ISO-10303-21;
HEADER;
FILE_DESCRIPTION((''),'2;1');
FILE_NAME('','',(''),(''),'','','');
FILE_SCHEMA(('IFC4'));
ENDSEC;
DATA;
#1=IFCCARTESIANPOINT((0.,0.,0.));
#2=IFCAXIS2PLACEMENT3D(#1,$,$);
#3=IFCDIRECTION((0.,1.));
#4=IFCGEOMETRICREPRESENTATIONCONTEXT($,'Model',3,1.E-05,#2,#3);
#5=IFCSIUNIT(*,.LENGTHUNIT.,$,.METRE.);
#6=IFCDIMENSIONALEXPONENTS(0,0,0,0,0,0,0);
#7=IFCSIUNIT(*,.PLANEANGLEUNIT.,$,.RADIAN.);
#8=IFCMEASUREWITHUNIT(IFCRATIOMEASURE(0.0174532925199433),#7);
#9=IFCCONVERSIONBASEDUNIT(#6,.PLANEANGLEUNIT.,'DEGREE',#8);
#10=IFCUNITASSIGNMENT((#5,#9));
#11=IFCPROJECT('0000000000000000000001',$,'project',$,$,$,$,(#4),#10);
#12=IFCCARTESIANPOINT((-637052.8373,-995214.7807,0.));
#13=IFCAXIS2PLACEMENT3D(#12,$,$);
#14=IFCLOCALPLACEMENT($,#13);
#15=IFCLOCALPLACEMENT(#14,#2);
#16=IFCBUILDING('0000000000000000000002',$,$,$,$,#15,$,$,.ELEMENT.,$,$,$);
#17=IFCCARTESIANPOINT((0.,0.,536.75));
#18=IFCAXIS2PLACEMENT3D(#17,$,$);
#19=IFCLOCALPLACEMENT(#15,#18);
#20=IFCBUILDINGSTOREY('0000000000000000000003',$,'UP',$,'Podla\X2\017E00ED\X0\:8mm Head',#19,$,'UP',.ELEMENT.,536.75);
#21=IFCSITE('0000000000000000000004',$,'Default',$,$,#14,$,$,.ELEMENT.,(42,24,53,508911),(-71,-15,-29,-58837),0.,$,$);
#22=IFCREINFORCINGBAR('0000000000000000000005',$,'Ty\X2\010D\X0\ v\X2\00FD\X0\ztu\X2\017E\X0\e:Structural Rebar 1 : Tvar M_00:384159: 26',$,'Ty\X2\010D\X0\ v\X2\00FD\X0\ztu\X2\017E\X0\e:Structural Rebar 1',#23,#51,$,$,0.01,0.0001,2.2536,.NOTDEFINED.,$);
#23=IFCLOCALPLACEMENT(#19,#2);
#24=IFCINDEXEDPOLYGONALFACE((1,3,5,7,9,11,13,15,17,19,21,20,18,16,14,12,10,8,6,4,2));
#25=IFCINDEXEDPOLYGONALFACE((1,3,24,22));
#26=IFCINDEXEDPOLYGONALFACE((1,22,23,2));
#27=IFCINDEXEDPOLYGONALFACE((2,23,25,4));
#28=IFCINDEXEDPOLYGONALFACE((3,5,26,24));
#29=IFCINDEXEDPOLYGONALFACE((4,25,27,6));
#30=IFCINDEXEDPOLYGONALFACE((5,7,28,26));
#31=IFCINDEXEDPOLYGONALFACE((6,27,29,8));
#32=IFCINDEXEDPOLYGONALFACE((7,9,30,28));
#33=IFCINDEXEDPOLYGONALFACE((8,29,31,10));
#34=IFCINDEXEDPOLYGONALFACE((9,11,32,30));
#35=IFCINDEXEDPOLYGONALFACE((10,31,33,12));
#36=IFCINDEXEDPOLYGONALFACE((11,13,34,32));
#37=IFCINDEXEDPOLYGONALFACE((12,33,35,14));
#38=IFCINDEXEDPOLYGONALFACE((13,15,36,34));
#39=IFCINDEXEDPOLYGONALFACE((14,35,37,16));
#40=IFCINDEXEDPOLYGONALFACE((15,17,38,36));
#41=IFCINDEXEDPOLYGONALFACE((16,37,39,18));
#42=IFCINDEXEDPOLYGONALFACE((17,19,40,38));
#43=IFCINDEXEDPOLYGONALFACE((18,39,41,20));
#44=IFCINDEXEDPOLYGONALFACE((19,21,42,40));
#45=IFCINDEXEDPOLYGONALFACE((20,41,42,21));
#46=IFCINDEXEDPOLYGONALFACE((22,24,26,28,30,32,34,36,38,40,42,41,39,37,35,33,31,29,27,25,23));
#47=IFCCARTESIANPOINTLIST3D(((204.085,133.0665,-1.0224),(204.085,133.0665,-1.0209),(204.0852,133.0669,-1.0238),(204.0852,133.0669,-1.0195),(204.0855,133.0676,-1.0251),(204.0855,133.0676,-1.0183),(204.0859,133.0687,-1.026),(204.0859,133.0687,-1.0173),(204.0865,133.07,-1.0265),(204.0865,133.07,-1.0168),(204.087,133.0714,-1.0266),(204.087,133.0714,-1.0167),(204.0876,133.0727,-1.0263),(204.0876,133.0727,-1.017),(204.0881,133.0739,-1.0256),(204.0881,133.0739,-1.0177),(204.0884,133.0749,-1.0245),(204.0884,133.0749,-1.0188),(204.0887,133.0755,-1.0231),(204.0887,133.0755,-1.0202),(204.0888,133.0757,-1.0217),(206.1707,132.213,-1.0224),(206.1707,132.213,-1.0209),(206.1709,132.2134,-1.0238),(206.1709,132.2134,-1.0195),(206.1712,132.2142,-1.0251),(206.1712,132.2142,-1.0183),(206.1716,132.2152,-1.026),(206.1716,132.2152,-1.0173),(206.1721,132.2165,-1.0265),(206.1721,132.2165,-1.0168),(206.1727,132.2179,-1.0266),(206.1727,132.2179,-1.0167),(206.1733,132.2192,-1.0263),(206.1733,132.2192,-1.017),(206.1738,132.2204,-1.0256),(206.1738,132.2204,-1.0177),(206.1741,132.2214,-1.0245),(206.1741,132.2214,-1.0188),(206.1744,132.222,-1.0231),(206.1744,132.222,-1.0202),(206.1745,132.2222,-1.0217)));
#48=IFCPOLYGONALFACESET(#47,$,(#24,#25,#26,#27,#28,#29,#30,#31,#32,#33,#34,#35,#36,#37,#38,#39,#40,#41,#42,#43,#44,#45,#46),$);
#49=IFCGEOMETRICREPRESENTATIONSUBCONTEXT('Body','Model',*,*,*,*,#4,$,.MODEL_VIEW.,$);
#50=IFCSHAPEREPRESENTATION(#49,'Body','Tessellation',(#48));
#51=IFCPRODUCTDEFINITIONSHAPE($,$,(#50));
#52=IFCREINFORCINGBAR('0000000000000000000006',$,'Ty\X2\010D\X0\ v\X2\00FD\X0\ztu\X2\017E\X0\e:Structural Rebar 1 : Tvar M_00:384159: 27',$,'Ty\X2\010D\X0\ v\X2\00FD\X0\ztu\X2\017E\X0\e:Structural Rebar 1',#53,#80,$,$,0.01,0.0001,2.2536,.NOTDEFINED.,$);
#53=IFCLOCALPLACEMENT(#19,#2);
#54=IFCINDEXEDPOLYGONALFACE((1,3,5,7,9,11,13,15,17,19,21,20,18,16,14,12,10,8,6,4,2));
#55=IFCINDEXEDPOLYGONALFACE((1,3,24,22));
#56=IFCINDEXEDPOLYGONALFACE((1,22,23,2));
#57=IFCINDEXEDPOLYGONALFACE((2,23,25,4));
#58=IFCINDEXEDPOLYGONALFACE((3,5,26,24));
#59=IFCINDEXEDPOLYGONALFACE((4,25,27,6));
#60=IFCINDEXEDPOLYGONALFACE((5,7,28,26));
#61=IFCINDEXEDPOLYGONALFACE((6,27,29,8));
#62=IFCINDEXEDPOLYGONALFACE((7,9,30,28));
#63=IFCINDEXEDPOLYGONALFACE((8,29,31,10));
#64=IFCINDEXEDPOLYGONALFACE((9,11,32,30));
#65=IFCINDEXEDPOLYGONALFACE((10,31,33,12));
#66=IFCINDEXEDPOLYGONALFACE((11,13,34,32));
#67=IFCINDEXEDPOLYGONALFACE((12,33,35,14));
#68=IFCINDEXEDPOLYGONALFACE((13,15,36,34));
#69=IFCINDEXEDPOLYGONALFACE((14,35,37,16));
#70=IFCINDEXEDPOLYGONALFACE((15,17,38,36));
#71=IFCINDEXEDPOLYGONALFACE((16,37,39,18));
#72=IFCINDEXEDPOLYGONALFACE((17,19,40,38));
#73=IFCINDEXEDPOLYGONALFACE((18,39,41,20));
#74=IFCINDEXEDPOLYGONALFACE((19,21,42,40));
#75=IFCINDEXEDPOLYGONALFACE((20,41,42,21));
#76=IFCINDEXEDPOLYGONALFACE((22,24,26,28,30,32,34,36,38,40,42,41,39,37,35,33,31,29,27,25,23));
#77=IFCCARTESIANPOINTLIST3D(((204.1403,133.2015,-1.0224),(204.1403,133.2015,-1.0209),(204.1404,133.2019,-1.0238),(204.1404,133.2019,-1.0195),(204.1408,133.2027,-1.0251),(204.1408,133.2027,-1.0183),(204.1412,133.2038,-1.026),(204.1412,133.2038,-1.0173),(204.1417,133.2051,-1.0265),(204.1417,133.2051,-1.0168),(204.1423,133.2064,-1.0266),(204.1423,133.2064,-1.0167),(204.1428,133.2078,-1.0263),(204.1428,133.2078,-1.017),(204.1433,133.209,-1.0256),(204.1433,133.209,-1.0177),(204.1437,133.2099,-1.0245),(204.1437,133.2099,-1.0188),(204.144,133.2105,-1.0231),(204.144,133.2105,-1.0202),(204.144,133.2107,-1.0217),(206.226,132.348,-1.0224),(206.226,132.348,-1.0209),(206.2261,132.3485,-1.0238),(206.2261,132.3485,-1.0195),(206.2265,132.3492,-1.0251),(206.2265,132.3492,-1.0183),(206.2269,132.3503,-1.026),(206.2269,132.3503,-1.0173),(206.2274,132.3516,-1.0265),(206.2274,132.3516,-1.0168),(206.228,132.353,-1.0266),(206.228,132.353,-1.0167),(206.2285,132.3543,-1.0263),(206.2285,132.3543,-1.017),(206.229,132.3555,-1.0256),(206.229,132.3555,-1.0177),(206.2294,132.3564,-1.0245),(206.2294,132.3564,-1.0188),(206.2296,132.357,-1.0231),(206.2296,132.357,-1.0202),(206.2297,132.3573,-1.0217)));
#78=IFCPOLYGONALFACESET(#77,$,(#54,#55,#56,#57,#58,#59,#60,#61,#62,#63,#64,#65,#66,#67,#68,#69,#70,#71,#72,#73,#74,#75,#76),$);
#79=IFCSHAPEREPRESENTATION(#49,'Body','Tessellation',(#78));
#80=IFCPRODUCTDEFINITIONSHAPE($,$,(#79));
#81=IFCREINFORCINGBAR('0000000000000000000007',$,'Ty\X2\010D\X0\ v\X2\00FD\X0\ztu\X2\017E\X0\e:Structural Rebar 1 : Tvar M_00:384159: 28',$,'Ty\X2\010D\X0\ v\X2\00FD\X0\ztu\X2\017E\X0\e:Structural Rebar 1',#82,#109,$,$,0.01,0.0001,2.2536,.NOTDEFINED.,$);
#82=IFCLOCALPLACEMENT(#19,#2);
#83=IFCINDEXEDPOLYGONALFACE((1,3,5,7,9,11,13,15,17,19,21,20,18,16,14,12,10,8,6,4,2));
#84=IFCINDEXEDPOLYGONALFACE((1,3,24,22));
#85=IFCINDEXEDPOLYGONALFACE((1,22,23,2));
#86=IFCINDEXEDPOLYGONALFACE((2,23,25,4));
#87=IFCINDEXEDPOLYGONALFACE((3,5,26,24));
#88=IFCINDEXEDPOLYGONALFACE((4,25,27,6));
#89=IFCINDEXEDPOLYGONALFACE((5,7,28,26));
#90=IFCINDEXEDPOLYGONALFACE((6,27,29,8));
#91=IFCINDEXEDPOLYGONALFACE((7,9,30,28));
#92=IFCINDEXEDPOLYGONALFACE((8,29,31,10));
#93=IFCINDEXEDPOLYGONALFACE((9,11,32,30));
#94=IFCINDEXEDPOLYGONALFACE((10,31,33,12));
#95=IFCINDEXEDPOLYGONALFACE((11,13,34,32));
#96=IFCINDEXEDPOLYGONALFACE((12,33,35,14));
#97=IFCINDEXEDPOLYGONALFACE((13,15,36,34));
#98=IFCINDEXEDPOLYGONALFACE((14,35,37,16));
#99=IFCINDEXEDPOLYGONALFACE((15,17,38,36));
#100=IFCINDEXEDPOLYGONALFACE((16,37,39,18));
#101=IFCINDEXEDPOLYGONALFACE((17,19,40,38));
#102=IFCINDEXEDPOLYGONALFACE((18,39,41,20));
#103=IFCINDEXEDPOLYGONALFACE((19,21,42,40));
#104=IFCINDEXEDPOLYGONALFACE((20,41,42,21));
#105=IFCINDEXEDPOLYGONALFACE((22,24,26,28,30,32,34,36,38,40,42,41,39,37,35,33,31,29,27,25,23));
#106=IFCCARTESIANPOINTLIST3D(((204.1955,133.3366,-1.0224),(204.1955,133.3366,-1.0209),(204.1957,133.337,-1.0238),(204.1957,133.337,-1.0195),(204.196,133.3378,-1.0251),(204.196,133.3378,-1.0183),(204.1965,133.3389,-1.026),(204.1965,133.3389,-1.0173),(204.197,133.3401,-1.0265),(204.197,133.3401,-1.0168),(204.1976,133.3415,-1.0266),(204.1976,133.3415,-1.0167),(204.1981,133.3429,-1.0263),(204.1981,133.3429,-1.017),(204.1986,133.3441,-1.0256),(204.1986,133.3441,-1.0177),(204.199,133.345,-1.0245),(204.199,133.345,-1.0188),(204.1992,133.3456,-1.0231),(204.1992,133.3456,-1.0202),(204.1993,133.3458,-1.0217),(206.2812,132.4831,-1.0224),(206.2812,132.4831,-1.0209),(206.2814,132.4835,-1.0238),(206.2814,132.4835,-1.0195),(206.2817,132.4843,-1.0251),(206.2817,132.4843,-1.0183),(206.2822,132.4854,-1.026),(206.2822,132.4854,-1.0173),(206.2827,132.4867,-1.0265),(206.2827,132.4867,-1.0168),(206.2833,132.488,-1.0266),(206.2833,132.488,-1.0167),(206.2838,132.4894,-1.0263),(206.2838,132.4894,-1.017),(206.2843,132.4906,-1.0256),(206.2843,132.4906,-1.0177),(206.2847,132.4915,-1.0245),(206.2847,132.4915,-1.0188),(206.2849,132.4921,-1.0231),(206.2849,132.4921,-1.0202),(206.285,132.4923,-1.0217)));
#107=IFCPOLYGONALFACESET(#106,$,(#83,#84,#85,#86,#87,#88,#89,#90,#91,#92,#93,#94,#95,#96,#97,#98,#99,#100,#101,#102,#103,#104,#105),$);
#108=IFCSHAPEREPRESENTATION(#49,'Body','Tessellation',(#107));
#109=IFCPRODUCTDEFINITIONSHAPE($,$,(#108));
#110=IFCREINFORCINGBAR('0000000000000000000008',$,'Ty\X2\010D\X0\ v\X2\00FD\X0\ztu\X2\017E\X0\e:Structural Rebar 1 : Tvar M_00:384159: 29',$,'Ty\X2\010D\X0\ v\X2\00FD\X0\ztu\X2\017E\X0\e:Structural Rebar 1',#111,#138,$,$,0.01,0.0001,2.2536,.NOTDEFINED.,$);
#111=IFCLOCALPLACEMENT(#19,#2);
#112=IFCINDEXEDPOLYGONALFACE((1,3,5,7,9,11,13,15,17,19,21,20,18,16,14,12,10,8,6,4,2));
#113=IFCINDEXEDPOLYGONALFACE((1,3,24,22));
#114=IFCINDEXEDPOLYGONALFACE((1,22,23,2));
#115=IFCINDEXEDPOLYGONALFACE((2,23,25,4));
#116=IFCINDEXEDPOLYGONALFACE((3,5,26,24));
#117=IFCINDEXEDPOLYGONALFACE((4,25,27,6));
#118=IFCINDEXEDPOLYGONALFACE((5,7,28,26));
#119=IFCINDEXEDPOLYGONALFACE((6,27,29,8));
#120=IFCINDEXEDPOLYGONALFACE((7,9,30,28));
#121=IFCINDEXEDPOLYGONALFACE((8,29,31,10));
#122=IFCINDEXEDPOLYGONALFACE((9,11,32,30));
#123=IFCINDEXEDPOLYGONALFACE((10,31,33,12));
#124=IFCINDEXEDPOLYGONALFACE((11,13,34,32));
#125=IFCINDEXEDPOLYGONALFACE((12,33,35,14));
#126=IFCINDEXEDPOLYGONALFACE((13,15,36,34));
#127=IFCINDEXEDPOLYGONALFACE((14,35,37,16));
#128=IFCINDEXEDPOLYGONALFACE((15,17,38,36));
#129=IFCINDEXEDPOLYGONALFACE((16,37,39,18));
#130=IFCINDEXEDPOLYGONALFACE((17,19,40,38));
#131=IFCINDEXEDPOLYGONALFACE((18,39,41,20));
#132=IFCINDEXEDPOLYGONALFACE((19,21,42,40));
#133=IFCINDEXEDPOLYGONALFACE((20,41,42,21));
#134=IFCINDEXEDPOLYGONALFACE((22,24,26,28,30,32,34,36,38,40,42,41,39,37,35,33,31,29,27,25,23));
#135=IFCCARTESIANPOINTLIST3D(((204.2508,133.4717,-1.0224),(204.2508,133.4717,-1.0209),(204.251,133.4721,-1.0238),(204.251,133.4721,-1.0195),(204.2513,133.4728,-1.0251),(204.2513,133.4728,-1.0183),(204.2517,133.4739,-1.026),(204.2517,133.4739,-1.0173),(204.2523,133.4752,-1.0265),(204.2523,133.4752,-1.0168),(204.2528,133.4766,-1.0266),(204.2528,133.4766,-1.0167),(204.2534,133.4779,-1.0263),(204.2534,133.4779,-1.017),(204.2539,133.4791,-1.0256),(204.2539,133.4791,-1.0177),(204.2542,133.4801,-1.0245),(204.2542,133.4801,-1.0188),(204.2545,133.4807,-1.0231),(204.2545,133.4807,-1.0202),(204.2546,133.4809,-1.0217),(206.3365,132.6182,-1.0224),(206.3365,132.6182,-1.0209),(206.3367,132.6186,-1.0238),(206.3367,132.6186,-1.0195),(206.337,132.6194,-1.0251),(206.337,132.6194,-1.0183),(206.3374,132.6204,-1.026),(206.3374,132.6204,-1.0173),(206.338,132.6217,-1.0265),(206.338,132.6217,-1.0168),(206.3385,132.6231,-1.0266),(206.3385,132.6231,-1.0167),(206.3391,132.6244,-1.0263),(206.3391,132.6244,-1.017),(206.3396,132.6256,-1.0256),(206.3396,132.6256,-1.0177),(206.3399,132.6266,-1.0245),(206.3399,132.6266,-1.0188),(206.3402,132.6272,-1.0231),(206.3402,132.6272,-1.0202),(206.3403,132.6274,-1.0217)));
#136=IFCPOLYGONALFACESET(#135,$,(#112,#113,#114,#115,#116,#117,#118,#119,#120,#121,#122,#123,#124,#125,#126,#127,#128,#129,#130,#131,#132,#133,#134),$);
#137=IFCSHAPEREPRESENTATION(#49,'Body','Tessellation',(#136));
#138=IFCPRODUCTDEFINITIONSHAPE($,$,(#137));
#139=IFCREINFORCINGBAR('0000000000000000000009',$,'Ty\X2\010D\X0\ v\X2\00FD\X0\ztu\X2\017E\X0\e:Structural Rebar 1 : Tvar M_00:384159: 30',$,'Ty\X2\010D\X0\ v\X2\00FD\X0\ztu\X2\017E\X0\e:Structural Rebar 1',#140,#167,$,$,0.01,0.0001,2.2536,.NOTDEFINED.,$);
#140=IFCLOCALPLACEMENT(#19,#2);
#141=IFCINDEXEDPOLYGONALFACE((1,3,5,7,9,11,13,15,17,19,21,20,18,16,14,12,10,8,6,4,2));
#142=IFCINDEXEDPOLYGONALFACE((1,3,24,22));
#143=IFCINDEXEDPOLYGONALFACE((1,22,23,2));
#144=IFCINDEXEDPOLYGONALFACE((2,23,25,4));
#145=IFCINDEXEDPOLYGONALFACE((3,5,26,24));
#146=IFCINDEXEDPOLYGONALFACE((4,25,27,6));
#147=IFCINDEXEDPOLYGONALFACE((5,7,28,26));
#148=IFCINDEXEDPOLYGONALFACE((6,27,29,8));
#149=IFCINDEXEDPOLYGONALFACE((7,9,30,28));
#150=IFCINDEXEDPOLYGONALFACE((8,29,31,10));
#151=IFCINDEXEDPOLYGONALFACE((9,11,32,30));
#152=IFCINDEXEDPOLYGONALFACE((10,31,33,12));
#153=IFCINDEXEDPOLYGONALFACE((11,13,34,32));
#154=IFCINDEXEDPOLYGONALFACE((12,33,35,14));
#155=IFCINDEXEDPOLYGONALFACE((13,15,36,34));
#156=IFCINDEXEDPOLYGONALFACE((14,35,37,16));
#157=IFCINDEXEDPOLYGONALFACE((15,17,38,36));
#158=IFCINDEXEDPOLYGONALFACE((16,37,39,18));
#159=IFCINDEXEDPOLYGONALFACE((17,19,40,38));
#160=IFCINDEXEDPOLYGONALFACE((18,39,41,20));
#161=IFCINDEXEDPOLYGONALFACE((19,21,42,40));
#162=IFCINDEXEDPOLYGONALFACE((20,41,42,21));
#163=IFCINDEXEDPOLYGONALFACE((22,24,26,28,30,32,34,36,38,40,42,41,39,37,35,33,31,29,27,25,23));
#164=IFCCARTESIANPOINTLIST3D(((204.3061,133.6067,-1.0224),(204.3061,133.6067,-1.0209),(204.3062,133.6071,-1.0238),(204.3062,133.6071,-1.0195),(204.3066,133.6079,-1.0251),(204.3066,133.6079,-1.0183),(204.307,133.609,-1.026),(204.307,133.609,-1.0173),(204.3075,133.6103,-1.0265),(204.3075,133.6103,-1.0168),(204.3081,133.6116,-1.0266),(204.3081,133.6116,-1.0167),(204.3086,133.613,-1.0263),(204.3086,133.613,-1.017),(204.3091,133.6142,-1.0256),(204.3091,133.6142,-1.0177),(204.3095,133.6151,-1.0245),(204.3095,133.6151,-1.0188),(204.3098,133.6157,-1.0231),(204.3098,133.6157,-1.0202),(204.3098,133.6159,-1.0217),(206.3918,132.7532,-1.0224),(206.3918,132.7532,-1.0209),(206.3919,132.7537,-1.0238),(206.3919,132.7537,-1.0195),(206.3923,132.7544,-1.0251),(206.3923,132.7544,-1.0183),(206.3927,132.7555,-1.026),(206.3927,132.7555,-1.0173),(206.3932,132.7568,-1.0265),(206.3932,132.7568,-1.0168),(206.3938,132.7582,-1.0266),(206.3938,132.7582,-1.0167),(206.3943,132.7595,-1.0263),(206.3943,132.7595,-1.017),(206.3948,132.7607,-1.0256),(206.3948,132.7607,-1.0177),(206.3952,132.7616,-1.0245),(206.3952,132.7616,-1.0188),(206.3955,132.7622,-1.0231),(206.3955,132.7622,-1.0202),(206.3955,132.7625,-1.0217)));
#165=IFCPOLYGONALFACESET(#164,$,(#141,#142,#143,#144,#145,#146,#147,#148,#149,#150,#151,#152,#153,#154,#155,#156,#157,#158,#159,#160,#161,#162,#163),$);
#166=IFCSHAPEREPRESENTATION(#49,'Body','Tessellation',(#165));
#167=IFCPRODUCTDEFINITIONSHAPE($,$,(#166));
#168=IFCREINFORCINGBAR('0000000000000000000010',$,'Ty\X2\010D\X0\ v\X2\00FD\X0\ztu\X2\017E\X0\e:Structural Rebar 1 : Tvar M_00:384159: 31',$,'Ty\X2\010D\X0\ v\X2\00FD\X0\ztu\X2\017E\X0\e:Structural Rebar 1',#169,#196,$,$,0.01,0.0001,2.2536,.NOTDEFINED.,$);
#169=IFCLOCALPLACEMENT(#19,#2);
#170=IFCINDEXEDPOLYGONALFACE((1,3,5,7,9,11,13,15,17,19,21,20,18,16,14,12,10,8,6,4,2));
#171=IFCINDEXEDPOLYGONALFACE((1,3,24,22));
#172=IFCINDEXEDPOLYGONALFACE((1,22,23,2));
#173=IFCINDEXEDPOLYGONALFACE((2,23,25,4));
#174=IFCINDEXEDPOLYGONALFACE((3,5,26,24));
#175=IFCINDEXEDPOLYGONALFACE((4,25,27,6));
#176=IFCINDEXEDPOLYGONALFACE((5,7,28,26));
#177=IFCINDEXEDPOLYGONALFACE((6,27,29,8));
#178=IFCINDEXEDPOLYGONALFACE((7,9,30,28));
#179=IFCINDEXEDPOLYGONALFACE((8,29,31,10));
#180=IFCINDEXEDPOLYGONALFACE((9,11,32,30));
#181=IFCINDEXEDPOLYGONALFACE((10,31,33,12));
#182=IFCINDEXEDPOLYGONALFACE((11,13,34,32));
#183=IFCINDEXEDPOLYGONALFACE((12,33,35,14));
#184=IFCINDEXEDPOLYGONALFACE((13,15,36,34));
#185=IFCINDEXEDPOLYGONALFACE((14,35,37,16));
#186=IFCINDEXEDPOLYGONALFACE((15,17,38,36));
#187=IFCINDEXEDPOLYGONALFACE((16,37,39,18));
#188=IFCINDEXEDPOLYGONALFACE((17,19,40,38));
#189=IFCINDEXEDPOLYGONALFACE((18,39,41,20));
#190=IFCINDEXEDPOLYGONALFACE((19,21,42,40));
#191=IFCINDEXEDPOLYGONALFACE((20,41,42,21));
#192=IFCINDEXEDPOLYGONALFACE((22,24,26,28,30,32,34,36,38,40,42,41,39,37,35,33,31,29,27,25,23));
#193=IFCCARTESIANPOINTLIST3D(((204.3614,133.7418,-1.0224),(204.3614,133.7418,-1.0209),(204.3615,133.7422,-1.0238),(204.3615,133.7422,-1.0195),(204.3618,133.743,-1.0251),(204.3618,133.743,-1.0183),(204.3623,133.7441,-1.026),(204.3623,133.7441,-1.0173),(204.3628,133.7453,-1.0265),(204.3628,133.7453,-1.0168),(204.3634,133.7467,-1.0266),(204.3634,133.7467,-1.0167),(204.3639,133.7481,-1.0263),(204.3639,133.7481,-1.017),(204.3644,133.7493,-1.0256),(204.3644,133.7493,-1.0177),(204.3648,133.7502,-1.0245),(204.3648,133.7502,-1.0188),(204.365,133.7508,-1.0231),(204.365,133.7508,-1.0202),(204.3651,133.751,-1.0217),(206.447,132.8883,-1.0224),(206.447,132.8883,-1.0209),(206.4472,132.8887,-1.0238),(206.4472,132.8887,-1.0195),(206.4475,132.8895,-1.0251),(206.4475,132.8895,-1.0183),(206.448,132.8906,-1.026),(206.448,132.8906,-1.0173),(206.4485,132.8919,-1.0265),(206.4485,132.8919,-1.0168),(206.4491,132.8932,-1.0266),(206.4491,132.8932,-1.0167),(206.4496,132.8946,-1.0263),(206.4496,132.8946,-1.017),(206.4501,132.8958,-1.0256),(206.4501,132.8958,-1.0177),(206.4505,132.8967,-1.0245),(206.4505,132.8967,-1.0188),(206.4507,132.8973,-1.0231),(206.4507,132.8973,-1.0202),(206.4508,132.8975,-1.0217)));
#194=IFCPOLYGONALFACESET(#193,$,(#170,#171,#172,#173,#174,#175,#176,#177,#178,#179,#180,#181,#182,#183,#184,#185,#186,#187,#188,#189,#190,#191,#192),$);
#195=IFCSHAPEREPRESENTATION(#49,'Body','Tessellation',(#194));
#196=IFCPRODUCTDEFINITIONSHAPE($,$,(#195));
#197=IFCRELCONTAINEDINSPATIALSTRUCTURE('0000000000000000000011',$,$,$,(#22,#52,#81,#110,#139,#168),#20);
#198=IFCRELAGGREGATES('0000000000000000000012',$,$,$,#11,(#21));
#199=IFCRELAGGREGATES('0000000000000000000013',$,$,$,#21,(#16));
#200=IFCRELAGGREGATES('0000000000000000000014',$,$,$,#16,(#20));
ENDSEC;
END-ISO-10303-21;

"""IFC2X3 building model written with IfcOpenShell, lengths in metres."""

from ifc_helpers import new_model, entity, si_unit, converted_unit, direction, frame, origin, place, context, subcontext, project, spatial, element, save


model = new_model("IFC2X3")

# Units and contexts
model_context = context("Model", 3, precision=1e-05, world=origin(), true_north=direction((0.0, 1.0)))
body_context = subcontext(model_context, "Body", "Model", "MODEL_VIEW")
ifc_project = project(units=[si_unit("LENGTHUNIT", "METRE"), converted_unit("PLANEANGLEUNIT", "DEGREE", entity("IfcRatioMeasure", 0.0174532925199433), si_unit("PLANEANGLEUNIT", "RADIAN"), dimensions=[0, 0, 0, 0, 0, 0, 0])], contexts=[model_context])

# Site, building, storey
site_placement = place(None, frame((-637052.8373, -995214.7807, 0.0)))
site = spatial("IfcSite", under=ifc_project, at=site_placement, Name="Default", CompositionType="ELEMENT", RefLatitude=(42, 24, 53, 508911), RefLongitude=(-71, -15, -29, -58837), RefElevation=0.0)
building_placement = place(site_placement, origin())
building = spatial("IfcBuilding", under=site, at=building_placement, CompositionType="ELEMENT")
storey_placement = place(building_placement, frame((0.0, 0.0, 536.75)))
storey = spatial("IfcBuildingStorey", under=building, at=storey_placement, Name="UP", ObjectType="Podlaží:8mm Head", LongName="UP", CompositionType="ELEMENT", Elevation=536.75)

# Reinforcing bars
reinforcing_bar_1_placement = place(storey_placement, origin())
element("IfcReinforcingBar", 1, at=reinforcing_bar_1_placement, inside=storey, Name="Tyč výztuže:Structural Rebar 1 : Tvar M_00:384159: 26", ObjectType="Tyč výztuže:Structural Rebar 1", BarLength=2.2536, BarRole="NOTDEFINED", CrossSectionArea=0.0001, NominalDiameter=0.01, context=body_context, shape_type="AdvancedSweptSolid", body=[
    entity("IfcSweptDiskSolid", entity("IfcCompositeCurve", [entity("IfcCompositeCurveSegment", "CONTINUOUS", True, entity("IfcPolyline", [entity("IfcCartesianPoint", [-206.1726, -132.2176, 1.0217]), entity("IfcCartesianPoint", [-204.0869, -133.071, 1.0217])]))], False), 0.005, None, 0.0, 1.0),
])
reinforcing_bar_2_placement = place(storey_placement, origin())
element("IfcReinforcingBar", 2, at=reinforcing_bar_2_placement, inside=storey, Name="Tyč výztuže:Structural Rebar 1 : Tvar M_00:384159: 27", ObjectType="Tyč výztuže:Structural Rebar 1", BarLength=2.2536, BarRole="NOTDEFINED", CrossSectionArea=0.0001, NominalDiameter=0.01, context=body_context, shape_type="AdvancedSweptSolid", body=[
    entity("IfcSweptDiskSolid", entity("IfcCompositeCurve", [entity("IfcCompositeCurveSegment", "CONTINUOUS", True, entity("IfcPolyline", [entity("IfcCartesianPoint", [-206.2278, -132.3526, 1.0217]), entity("IfcCartesianPoint", [-204.1421, -133.2061, 1.0217])]))], False), 0.005, None, 0.0, 1.0),
])
reinforcing_bar_3_placement = place(storey_placement, origin())
element("IfcReinforcingBar", 3, at=reinforcing_bar_3_placement, inside=storey, Name="Tyč výztuže:Structural Rebar 1 : Tvar M_00:384159: 28", ObjectType="Tyč výztuže:Structural Rebar 1", BarLength=2.2536, BarRole="NOTDEFINED", CrossSectionArea=0.0001, NominalDiameter=0.01, context=body_context, shape_type="AdvancedSweptSolid", body=[
    entity("IfcSweptDiskSolid", entity("IfcCompositeCurve", [entity("IfcCompositeCurveSegment", "CONTINUOUS", True, entity("IfcPolyline", [entity("IfcCartesianPoint", [-206.2831, -132.4877, 1.0217]), entity("IfcCartesianPoint", [-204.1974, -133.3412, 1.0217])]))], False), 0.005, None, 0.0, 1.0),
])
reinforcing_bar_4_placement = place(storey_placement, origin())
element("IfcReinforcingBar", 4, at=reinforcing_bar_4_placement, inside=storey, Name="Tyč výztuže:Structural Rebar 1 : Tvar M_00:384159: 29", ObjectType="Tyč výztuže:Structural Rebar 1", BarLength=2.2536, BarRole="NOTDEFINED", CrossSectionArea=0.0001, NominalDiameter=0.01, context=body_context, shape_type="AdvancedSweptSolid", body=[
    entity("IfcSweptDiskSolid", entity("IfcCompositeCurve", [entity("IfcCompositeCurveSegment", "CONTINUOUS", True, entity("IfcPolyline", [entity("IfcCartesianPoint", [-206.3384, -132.6228, 1.0217]), entity("IfcCartesianPoint", [-204.2527, -133.4762, 1.0217])]))], False), 0.005, None, 0.0, 1.0),
])
reinforcing_bar_5_placement = place(storey_placement, origin())
element("IfcReinforcingBar", 5, at=reinforcing_bar_5_placement, inside=storey, Name="Tyč výztuže:Structural Rebar 1 : Tvar M_00:384159: 30", ObjectType="Tyč výztuže:Structural Rebar 1", BarLength=2.2536, BarRole="NOTDEFINED", CrossSectionArea=0.0001, NominalDiameter=0.01, context=body_context, shape_type="AdvancedSweptSolid", body=[
    entity("IfcSweptDiskSolid", entity("IfcCompositeCurve", [entity("IfcCompositeCurveSegment", "CONTINUOUS", True, entity("IfcPolyline", [entity("IfcCartesianPoint", [-206.3936, -132.7578, 1.0217]), entity("IfcCartesianPoint", [-204.308, -133.6113, 1.0217])]))], False), 0.005, None, 0.0, 1.0),
])
reinforcing_bar_6_placement = place(storey_placement, origin())
element("IfcReinforcingBar", 6, at=reinforcing_bar_6_placement, inside=storey, Name="Tyč výztuže:Structural Rebar 1 : Tvar M_00:384159: 31", ObjectType="Tyč výztuže:Structural Rebar 1", BarLength=2.2536, BarRole="NOTDEFINED", CrossSectionArea=0.0001, NominalDiameter=0.01, context=body_context, shape_type="AdvancedSweptSolid", body=[
    entity("IfcSweptDiskSolid", entity("IfcCompositeCurve", [entity("IfcCompositeCurveSegment", "CONTINUOUS", True, entity("IfcPolyline", [entity("IfcCartesianPoint", [-206.4489, -132.8929, 1.0217]), entity("IfcCartesianPoint", [-204.3632, -133.7464, 1.0217])]))], False), 0.005, None, 0.0, 1.0),
])

save(model, "model.ifc")
